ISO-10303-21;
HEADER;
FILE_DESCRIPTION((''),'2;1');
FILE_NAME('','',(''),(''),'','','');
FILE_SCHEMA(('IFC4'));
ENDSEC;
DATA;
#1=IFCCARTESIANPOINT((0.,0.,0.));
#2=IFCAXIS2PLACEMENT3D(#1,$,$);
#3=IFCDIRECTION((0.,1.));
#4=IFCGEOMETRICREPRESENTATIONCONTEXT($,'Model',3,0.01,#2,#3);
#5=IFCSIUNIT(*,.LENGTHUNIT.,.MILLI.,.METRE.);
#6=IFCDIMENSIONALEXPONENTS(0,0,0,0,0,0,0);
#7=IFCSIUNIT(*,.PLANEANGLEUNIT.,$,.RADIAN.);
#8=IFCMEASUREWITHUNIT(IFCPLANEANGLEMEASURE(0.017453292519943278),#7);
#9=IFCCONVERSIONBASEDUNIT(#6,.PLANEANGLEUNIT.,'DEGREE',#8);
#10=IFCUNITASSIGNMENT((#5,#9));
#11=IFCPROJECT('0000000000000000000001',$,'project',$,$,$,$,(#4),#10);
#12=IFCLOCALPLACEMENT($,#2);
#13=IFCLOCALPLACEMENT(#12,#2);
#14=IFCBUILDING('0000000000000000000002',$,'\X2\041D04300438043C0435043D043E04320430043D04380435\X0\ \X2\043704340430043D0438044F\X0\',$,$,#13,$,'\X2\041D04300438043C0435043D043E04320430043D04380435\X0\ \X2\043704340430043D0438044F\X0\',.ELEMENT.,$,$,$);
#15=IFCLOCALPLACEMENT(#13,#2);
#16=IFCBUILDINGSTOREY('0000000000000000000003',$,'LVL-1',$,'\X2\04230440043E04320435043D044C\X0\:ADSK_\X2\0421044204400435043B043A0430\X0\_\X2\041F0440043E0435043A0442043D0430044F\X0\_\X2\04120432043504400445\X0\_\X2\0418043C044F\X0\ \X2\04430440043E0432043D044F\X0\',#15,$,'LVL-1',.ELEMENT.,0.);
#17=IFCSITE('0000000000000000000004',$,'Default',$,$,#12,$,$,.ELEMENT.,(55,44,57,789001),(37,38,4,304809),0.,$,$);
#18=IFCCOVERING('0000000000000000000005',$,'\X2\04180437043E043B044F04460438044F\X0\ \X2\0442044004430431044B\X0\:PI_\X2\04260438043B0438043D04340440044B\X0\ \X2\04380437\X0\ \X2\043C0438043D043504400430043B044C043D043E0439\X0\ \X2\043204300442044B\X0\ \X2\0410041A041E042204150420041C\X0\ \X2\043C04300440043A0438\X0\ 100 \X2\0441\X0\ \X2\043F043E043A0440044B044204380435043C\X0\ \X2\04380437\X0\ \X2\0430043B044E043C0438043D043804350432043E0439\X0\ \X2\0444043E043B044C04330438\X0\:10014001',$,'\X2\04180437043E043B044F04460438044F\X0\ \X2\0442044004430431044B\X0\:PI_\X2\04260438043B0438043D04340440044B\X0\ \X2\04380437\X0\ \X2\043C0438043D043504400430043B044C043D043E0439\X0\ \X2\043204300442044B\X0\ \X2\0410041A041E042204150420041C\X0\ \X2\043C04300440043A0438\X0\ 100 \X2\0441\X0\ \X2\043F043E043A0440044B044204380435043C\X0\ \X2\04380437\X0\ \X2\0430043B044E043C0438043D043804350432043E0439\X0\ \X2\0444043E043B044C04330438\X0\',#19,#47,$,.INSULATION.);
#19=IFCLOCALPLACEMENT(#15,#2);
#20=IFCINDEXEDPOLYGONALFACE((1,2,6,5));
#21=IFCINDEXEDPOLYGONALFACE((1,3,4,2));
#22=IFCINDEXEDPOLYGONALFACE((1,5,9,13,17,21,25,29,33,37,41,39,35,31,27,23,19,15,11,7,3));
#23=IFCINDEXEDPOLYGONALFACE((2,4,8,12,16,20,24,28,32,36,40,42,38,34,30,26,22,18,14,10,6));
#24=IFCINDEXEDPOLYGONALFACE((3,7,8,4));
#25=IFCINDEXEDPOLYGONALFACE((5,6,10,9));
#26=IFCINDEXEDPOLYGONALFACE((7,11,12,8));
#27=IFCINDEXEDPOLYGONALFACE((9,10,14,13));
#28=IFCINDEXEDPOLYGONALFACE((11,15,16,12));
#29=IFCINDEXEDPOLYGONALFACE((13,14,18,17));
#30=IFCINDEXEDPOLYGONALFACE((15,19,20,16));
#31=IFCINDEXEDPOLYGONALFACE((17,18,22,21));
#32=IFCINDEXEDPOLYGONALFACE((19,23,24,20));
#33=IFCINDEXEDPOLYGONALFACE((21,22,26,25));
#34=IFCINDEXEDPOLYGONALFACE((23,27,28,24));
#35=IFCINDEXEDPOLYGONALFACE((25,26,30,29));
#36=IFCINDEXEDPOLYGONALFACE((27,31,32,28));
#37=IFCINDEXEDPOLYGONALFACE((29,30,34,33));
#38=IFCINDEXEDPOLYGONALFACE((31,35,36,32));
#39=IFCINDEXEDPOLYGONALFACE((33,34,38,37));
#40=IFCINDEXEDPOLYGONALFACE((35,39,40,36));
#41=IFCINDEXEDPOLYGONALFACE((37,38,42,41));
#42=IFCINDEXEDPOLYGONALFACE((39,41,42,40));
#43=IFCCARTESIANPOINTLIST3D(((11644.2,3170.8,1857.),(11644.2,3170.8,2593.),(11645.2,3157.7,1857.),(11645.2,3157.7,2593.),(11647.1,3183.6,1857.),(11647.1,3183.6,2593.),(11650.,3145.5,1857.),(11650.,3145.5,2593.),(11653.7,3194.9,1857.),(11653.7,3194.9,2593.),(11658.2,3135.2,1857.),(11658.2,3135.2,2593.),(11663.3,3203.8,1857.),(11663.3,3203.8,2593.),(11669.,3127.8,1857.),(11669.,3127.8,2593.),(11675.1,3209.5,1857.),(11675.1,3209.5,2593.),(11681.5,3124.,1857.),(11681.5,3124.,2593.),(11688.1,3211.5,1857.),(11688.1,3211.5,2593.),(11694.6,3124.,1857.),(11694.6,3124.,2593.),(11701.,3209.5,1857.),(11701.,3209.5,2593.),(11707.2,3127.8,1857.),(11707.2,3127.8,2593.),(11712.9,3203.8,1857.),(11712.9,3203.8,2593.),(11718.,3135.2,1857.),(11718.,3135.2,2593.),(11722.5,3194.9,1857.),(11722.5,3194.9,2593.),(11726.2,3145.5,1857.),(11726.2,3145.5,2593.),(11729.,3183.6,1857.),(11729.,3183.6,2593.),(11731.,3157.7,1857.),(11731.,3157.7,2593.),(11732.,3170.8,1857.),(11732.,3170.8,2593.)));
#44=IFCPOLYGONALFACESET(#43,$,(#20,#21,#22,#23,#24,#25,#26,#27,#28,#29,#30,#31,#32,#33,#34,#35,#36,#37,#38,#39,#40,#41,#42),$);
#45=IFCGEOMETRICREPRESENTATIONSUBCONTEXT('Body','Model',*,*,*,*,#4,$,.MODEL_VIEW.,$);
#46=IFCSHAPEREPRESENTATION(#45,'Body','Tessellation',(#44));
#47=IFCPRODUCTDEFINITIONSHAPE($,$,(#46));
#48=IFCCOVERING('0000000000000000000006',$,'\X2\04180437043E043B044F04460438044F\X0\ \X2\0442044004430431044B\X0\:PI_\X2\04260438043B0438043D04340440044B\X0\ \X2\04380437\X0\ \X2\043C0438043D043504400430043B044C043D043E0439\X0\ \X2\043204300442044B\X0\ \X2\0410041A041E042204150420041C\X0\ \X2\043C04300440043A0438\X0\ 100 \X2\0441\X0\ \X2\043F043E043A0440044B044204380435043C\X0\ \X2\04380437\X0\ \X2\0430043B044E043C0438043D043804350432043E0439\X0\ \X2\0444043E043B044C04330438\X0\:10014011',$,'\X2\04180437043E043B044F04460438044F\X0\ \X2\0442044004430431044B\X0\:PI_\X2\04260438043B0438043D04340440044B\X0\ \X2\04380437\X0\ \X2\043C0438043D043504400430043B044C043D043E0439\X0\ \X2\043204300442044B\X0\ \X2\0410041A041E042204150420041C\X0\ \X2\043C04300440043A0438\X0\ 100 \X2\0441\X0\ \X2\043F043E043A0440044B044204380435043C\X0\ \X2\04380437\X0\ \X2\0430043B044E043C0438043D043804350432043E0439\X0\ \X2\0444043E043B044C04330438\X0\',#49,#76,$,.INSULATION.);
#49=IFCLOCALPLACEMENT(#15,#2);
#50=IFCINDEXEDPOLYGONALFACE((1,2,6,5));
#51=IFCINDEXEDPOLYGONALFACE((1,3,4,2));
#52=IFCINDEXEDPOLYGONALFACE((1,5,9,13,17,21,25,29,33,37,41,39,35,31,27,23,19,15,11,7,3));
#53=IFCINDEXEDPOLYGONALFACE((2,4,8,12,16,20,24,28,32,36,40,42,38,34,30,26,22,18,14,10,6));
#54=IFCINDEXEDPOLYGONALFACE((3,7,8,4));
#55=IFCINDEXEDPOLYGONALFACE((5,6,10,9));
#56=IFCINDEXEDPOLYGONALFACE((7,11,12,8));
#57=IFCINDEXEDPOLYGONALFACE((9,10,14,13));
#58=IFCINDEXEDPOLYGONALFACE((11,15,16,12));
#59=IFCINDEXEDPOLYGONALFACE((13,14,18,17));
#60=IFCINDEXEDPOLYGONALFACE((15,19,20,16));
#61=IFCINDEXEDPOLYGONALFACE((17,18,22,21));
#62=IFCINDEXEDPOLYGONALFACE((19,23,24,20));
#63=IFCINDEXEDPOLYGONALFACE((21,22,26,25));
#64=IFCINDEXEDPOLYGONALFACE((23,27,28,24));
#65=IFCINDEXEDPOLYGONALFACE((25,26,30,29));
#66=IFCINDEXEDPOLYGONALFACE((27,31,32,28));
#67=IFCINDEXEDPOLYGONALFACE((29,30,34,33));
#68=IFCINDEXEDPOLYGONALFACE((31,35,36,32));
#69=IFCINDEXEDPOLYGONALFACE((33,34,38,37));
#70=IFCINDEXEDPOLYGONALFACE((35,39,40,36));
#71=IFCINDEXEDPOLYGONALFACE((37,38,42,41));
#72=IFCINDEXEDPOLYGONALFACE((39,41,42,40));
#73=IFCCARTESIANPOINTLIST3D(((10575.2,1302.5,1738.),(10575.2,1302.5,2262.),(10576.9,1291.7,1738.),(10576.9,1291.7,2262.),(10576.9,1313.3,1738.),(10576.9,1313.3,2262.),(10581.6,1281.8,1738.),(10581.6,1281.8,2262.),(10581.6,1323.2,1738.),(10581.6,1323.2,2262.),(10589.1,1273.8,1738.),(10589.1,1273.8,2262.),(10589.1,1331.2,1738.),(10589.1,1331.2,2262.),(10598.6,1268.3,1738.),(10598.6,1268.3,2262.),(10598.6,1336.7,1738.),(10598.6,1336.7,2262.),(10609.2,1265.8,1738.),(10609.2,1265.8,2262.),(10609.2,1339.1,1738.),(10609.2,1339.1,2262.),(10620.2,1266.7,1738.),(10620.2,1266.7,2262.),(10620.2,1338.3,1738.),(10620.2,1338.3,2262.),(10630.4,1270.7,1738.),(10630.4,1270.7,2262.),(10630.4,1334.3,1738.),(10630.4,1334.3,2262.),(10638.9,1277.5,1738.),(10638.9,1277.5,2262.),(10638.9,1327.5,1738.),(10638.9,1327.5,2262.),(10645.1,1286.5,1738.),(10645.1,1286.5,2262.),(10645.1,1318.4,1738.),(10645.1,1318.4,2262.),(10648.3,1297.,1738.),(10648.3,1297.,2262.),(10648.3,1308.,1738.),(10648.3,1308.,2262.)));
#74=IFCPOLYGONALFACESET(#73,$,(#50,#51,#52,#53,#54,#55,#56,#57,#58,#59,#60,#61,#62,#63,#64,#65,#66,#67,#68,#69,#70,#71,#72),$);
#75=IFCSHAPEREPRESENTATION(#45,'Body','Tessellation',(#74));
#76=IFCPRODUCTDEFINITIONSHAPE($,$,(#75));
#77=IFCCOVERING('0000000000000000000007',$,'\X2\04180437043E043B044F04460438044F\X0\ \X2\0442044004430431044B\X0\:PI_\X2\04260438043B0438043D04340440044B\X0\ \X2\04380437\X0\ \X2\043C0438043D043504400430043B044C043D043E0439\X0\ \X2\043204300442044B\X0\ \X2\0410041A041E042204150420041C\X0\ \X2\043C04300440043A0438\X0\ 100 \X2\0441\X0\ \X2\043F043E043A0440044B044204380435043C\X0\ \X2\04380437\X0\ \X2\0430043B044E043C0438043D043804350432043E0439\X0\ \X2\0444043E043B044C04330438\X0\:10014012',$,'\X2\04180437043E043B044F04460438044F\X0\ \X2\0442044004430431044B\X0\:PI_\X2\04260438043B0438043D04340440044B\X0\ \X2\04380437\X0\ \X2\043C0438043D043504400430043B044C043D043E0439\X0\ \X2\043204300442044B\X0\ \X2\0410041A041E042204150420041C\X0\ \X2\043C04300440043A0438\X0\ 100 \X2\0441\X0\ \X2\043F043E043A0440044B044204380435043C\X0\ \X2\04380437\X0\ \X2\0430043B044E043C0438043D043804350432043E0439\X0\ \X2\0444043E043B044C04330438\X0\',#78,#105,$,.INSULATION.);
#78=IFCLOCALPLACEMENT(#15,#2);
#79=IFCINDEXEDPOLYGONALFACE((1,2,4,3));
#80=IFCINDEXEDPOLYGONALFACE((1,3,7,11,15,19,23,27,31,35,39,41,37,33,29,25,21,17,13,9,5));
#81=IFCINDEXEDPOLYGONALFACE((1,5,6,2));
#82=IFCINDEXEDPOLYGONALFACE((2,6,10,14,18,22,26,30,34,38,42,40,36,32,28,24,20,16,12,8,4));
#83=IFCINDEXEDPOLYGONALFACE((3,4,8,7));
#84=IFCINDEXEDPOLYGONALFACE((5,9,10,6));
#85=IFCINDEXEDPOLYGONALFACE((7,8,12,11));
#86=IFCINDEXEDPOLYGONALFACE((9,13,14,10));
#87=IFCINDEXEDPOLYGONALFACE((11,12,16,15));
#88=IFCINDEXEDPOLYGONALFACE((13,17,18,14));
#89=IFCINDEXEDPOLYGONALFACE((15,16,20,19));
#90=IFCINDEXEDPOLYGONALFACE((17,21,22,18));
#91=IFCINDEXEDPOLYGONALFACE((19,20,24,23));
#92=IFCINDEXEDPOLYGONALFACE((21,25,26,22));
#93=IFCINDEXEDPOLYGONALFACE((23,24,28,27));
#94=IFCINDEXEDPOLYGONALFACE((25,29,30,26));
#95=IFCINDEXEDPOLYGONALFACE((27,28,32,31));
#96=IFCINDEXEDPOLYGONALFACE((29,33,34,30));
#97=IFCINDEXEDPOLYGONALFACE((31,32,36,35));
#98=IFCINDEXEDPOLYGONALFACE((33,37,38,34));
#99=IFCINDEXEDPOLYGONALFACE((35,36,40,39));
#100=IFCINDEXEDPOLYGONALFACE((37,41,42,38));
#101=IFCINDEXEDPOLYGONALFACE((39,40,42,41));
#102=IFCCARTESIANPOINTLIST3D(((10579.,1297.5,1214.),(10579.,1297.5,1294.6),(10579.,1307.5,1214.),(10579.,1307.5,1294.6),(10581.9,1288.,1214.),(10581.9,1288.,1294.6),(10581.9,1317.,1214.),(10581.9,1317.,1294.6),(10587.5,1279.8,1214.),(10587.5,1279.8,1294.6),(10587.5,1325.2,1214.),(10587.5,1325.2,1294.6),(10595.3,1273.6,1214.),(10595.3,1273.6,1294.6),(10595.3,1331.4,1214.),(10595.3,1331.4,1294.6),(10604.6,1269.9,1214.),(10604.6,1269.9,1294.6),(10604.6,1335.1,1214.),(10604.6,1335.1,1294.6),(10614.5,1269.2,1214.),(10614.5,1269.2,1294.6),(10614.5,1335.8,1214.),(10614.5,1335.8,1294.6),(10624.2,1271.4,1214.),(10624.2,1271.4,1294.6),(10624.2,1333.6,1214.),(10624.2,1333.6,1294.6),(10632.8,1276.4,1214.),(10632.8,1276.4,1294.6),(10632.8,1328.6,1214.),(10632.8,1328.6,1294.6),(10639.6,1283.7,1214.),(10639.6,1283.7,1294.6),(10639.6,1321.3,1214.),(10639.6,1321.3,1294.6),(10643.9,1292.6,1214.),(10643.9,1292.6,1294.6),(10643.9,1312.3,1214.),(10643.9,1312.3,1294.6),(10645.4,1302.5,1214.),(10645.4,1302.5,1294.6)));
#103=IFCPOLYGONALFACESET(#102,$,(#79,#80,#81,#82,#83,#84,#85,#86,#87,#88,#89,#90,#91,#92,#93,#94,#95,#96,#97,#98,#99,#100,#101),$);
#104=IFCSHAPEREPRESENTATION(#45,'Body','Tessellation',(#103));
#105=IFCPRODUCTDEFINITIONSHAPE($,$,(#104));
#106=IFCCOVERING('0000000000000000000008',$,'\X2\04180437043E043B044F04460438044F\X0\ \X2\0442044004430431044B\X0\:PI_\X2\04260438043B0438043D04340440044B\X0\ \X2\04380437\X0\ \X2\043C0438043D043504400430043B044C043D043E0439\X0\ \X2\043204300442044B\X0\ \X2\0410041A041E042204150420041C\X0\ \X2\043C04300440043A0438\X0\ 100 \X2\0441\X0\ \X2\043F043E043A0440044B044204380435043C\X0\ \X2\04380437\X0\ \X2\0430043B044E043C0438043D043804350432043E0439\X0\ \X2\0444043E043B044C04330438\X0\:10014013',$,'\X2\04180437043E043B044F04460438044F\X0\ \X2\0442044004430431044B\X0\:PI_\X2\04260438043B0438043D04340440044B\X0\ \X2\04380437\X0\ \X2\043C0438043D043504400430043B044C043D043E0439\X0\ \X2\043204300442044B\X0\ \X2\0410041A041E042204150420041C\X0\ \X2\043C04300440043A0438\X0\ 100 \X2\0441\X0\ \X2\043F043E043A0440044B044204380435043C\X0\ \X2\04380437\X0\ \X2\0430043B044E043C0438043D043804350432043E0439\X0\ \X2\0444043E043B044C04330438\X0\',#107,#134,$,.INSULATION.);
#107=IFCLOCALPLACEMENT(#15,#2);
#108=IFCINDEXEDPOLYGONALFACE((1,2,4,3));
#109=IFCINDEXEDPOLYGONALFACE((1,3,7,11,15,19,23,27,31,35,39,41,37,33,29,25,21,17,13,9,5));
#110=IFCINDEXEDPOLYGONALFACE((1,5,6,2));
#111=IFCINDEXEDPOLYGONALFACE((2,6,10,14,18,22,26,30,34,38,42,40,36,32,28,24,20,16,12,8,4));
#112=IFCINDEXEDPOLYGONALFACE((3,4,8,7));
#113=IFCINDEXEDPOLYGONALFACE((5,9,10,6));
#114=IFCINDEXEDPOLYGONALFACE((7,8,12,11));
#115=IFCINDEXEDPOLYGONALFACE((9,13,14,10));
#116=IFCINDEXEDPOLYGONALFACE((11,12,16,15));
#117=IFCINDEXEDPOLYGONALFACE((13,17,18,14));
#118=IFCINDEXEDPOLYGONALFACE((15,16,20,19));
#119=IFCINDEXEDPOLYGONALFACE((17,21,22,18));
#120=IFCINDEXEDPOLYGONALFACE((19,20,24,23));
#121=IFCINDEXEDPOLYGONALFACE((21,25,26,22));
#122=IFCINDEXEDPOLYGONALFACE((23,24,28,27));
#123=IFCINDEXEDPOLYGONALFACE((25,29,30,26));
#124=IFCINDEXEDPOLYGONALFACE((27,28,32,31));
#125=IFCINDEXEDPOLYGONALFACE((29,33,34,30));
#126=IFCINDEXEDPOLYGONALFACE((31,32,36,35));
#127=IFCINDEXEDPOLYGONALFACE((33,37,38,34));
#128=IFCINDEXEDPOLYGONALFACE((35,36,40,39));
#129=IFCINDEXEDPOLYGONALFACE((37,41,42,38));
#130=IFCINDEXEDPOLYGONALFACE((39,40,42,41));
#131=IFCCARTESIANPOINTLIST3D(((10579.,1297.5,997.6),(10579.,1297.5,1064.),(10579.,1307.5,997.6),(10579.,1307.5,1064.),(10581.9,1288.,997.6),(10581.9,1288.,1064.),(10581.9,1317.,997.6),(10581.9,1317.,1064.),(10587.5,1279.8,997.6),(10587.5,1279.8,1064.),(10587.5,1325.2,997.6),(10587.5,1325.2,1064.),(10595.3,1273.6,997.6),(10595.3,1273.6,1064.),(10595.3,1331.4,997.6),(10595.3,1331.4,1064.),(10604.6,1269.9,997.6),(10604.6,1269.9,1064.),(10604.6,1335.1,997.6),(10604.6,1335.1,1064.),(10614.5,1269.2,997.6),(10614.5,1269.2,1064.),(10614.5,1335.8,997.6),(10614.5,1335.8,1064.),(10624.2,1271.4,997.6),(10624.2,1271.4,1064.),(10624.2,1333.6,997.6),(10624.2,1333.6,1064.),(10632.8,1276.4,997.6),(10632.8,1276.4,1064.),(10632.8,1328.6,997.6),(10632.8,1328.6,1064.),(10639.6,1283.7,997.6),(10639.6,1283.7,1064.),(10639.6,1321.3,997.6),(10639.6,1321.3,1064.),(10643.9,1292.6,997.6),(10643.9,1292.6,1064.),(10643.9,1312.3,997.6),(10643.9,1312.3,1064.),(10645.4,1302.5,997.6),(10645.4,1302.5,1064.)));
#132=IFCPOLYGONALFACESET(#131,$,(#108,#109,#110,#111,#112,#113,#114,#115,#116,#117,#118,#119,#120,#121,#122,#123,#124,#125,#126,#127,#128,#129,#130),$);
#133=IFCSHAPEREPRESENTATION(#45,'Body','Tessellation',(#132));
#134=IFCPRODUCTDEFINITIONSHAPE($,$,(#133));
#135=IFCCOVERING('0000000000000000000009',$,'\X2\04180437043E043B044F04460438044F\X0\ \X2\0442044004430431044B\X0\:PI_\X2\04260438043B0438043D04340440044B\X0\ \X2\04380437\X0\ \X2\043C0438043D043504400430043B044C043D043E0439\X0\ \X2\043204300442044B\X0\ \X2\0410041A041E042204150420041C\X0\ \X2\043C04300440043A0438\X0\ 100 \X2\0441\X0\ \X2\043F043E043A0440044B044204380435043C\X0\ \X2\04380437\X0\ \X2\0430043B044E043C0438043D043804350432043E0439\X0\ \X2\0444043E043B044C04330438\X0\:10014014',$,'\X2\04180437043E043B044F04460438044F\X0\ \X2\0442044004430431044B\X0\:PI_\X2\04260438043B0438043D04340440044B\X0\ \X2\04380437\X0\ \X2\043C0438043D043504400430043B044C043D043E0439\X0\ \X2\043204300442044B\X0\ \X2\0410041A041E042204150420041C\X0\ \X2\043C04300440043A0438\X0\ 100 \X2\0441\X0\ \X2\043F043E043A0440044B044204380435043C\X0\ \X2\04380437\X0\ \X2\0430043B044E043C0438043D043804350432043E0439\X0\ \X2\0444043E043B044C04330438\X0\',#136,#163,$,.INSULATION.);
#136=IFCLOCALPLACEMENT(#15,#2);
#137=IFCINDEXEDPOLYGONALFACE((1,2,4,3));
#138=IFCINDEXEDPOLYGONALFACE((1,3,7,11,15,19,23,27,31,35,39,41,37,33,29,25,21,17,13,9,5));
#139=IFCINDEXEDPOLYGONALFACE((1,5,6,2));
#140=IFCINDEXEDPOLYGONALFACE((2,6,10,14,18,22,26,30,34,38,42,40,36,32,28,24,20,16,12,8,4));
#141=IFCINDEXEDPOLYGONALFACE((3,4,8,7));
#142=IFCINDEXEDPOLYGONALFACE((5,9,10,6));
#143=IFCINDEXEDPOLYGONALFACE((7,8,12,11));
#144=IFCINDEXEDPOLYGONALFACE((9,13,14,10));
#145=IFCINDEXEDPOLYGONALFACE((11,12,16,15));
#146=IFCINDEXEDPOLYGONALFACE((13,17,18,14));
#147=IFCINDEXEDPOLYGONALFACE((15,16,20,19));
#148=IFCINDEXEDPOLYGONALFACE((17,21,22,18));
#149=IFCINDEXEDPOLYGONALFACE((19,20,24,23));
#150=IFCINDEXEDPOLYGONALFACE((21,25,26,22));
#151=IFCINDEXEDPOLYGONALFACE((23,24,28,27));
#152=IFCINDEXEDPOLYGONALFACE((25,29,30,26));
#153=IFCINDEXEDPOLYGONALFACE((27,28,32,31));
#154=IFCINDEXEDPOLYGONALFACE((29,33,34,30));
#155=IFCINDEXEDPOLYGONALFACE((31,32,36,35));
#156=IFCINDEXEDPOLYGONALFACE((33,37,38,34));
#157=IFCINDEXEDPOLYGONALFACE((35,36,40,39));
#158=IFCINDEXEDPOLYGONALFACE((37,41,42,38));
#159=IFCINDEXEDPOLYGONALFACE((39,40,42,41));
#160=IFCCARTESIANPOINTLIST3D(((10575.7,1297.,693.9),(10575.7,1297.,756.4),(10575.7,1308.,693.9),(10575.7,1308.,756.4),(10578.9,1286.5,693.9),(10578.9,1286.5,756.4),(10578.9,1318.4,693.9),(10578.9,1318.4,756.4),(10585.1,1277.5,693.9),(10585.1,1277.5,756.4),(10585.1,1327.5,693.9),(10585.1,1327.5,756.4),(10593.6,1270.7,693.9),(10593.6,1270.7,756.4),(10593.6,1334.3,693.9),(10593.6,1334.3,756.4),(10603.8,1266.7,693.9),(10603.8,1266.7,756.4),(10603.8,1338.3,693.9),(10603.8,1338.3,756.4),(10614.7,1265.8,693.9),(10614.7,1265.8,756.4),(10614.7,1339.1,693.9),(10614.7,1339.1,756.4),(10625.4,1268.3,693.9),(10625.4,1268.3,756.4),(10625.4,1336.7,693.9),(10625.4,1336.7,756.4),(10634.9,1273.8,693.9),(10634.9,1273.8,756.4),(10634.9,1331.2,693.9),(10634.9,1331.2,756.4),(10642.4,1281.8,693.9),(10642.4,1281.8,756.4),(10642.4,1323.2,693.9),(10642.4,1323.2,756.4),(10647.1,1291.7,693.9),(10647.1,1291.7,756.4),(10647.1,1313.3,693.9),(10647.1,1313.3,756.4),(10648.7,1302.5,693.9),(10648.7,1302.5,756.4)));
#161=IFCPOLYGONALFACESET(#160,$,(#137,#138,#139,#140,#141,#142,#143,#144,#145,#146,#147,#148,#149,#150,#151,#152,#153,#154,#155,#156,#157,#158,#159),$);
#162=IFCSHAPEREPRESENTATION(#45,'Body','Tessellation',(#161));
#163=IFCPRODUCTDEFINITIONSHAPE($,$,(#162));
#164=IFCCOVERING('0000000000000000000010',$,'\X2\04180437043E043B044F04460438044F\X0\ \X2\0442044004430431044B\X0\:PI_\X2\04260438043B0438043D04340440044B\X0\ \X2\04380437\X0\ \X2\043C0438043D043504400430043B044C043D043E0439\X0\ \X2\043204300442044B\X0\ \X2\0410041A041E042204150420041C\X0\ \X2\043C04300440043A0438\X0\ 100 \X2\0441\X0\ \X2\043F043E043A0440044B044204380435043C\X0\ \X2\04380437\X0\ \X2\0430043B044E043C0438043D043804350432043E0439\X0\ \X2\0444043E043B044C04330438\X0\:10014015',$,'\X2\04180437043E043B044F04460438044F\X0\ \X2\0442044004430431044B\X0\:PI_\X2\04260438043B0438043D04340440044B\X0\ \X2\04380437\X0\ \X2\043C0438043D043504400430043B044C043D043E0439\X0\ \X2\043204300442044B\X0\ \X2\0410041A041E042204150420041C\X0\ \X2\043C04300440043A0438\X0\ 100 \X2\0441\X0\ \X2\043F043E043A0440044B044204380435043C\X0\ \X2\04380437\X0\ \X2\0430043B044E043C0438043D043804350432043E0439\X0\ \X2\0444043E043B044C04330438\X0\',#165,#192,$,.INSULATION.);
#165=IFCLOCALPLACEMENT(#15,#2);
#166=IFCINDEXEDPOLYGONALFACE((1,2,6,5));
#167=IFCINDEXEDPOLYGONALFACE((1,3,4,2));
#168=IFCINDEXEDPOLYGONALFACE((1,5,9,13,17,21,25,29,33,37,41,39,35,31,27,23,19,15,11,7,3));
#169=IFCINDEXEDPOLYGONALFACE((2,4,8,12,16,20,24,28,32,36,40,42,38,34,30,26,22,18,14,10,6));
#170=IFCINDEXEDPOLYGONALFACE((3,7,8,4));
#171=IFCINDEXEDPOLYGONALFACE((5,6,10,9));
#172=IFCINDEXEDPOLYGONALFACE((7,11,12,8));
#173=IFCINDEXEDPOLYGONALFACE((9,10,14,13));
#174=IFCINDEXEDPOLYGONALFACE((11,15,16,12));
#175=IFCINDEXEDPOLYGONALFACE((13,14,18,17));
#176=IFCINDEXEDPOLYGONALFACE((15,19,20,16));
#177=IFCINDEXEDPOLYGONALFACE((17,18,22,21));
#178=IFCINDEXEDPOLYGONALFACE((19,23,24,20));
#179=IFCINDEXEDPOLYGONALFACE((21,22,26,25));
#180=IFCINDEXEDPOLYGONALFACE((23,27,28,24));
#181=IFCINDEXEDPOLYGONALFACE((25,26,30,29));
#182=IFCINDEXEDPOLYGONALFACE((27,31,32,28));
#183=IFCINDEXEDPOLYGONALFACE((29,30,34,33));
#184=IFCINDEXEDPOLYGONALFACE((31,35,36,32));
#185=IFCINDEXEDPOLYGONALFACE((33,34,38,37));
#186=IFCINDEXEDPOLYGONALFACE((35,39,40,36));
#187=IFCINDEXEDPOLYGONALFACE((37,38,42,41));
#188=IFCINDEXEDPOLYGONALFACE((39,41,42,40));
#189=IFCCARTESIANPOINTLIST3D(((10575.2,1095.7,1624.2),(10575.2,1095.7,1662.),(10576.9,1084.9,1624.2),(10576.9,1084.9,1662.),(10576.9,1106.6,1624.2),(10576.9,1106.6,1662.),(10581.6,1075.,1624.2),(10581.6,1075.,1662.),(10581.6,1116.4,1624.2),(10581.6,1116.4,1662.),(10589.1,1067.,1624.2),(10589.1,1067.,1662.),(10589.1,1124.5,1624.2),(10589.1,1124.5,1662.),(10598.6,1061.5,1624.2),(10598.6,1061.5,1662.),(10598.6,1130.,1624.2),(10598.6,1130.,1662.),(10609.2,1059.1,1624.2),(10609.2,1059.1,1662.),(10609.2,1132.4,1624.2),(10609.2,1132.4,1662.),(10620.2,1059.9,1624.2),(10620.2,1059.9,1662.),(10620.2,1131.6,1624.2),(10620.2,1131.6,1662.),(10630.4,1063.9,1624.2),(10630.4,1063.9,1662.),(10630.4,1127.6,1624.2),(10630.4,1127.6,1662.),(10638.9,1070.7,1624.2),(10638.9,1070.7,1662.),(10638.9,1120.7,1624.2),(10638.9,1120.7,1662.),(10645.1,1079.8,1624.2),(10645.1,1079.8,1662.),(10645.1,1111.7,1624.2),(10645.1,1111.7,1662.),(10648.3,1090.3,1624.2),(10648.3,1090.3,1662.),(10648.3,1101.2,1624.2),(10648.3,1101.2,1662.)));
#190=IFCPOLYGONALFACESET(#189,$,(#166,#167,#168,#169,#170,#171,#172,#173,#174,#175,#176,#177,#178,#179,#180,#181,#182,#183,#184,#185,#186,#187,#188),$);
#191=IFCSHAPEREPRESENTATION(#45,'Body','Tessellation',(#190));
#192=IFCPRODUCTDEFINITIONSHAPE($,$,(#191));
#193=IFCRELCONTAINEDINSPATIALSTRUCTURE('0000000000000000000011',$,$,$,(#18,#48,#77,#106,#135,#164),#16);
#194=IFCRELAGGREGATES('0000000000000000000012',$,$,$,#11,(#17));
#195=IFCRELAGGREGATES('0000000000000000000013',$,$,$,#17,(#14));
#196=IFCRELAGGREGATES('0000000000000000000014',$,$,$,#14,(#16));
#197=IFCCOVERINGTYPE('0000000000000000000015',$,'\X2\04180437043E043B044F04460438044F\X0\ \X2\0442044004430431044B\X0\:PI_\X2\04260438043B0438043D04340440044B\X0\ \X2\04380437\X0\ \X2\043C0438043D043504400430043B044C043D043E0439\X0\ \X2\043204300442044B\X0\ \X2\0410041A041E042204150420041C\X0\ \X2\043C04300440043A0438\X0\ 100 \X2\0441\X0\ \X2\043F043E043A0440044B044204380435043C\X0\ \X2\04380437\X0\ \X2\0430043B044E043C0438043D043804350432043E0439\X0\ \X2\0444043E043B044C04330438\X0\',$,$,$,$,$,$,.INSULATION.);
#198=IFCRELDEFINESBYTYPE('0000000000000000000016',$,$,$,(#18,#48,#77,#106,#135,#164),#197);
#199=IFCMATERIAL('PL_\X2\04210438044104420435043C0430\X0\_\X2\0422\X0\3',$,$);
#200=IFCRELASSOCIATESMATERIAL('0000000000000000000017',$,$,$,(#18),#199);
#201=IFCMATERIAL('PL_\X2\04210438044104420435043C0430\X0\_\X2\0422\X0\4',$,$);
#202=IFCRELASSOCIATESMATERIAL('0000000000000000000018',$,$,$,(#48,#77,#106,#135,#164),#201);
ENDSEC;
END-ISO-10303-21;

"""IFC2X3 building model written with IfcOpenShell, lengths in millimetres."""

from ifc_helpers import new_model, entity, si_unit, converted_unit, direction, frame, frame_2d, origin, origin_2d_with_axis, place, context, subcontext, project, spatial, circle, extrude, material, type_object, element, save


model = new_model("IFC2X3")

# Units and contexts
model_context = context("Model", 3, precision=0.01, world=origin(), true_north=direction((0.0, 1.0)))
body_context = subcontext(model_context, "Body", "Model", "MODEL_VIEW")
ifc_project = project(units=[si_unit("LENGTHUNIT", "METRE", prefix="MILLI"), converted_unit("PLANEANGLEUNIT", "DEGREE", entity("IfcPlaneAngleMeasure", 0.017453292519943278), si_unit("PLANEANGLEUNIT", "RADIAN"), dimensions=[0, 0, 0, 0, 0, 0, 0])], contexts=[model_context])

# Site, building, storey
site_placement = place(None, origin())
site = spatial("IfcSite", under=ifc_project, at=site_placement, Name="Default", CompositionType="ELEMENT", RefLatitude=(55, 44, 57, 789001), RefLongitude=(37, 38, 4, 304809), RefElevation=0.0)
building_placement = place(site_placement, origin())
building = spatial("IfcBuilding", under=site, at=building_placement, Name="Наименование здания", LongName="Наименование здания", CompositionType="ELEMENT")
storey_placement = place(building_placement, origin())
storey = spatial("IfcBuildingStorey", under=building, at=storey_placement, Name="LVL-1", ObjectType="Уровень:ADSK_Стрелка_Проектная_Вверх_Имя уровня", LongName="LVL-1", CompositionType="ELEMENT", Elevation=0.0)

# Coverings
ifc_material_1 = material(Name="PL_Система_Т3")
covering_type = type_object("IfcCoveringType", Name="Изоляция трубы:PI_Цилиндры из минеральной ваты АКОТЕРМ марки 100 с покрытием из алюминиевой фольги", PredefinedType="INSULATION")
covering_1_placement = place(storey_placement, origin())
element("IfcCovering", 1, at=covering_1_placement, inside=storey, type_object=covering_type, material=ifc_material_1, Name="Изоляция трубы:PI_Цилиндры из минеральной ваты АКОТЕРМ марки 100 с покрытием из алюминиевой фольги:10014001", ObjectType="Изоляция трубы:PI_Цилиндры из минеральной ваты АКОТЕРМ марки 100 с покрытием из алюминиевой фольги", PredefinedType="INSULATION", context=body_context, shape_type="SweptSolid", body=[
    extrude(circle(Radius=44.0, at=origin_2d_with_axis()), frame((11688.1, 3167.5, 1857.0), z_axis=(0.0, 0.0, 1.0), x_axis=(0.0, 1.0, 0.0)), (0.0, 0.0, 1.0), 736.0),
])
ifc_material_2 = material(Name="PL_Система_Т4")
covering_2_placement = place(storey_placement, origin())
element("IfcCovering", 2, at=covering_2_placement, inside=storey, type_object=covering_type, material=ifc_material_2, Name="Изоляция трубы:PI_Цилиндры из минеральной ваты АКОТЕРМ марки 100 с покрытием из алюминиевой фольги:10014011", ObjectType="Изоляция трубы:PI_Цилиндры из минеральной ваты АКОТЕРМ марки 100 с покрытием из алюминиевой фольги", PredefinedType="INSULATION", context=body_context, shape_type="SweptSolid", body=[
    extrude(circle(Radius=36.8, at=origin_2d_with_axis()), frame((10612.0, 1302.5, 1738.0), z_axis=(0.0, 0.0, 1.0), x_axis=(-1.0, 0.0, 0.0)), (0.0, 0.0, 1.0), 524.0),
])
covering_3_placement = place(storey_placement, origin())
element("IfcCovering", 3, at=covering_3_placement, inside=storey, type_object=covering_type, material=ifc_material_2, Name="Изоляция трубы:PI_Цилиндры из минеральной ваты АКОТЕРМ марки 100 с покрытием из алюминиевой фольги:10014012", ObjectType="Изоляция трубы:PI_Цилиндры из минеральной ваты АКОТЕРМ марки 100 с покрытием из алюминиевой фольги", PredefinedType="INSULATION", context=body_context, shape_type="SweptSolid", body=[
    extrude(circle(Radius=33.4, at=frame_2d((0.0, 0.0), x_axis=(1.0, 0.0))), frame((10612.0, 1302.5, 1214.0)), (0.0, 0.0, 1.0), 80.6),
])
covering_4_placement = place(storey_placement, origin())
element("IfcCovering", 4, at=covering_4_placement, inside=storey, type_object=covering_type, material=ifc_material_2, Name="Изоляция трубы:PI_Цилиндры из минеральной ваты АКОТЕРМ марки 100 с покрытием из алюминиевой фольги:10014013", ObjectType="Изоляция трубы:PI_Цилиндры из минеральной ваты АКОТЕРМ марки 100 с покрытием из алюминиевой фольги", PredefinedType="INSULATION", context=body_context, shape_type="SweptSolid", body=[
    extrude(circle(Radius=33.4, at=frame_2d((0.0, 0.0), x_axis=(1.0, 0.0))), frame((10612.0, 1302.5, 997.6)), (0.0, 0.0, 1.0), 66.4),
])
covering_5_placement = place(storey_placement, origin())
element("IfcCovering", 5, at=covering_5_placement, inside=storey, type_object=covering_type, material=ifc_material_2, Name="Изоляция трубы:PI_Цилиндры из минеральной ваты АКОТЕРМ марки 100 с покрытием из алюминиевой фольги:10014014", ObjectType="Изоляция трубы:PI_Цилиндры из минеральной ваты АКОТЕРМ марки 100 с покрытием из алюминиевой фольги", PredefinedType="INSULATION", context=body_context, shape_type="SweptSolid", body=[
    extrude(circle(Radius=36.8, at=frame_2d((0.0, 0.0), x_axis=(1.0, 0.0))), frame((10612.0, 1302.5, 693.9)), (0.0, 0.0, 1.0), 62.6),
])
covering_6_placement = place(storey_placement, origin())
element("IfcCovering", 6, at=covering_6_placement, inside=storey, type_object=covering_type, material=ifc_material_2, Name="Изоляция трубы:PI_Цилиндры из минеральной ваты АКОТЕРМ марки 100 с покрытием из алюминиевой фольги:10014015", ObjectType="Изоляция трубы:PI_Цилиндры из минеральной ваты АКОТЕРМ марки 100 с покрытием из алюминиевой фольги", PredefinedType="INSULATION", context=body_context, shape_type="SweptSolid", body=[
    extrude(circle(Radius=36.8, at=origin_2d_with_axis()), frame((10612.0, 1095.7, 1624.2), z_axis=(0.0, 0.0, 1.0), x_axis=(-1.0, 0.0, 0.0)), (0.0, 0.0, 1.0), 37.8),
])

save(model, "model.ifc")
